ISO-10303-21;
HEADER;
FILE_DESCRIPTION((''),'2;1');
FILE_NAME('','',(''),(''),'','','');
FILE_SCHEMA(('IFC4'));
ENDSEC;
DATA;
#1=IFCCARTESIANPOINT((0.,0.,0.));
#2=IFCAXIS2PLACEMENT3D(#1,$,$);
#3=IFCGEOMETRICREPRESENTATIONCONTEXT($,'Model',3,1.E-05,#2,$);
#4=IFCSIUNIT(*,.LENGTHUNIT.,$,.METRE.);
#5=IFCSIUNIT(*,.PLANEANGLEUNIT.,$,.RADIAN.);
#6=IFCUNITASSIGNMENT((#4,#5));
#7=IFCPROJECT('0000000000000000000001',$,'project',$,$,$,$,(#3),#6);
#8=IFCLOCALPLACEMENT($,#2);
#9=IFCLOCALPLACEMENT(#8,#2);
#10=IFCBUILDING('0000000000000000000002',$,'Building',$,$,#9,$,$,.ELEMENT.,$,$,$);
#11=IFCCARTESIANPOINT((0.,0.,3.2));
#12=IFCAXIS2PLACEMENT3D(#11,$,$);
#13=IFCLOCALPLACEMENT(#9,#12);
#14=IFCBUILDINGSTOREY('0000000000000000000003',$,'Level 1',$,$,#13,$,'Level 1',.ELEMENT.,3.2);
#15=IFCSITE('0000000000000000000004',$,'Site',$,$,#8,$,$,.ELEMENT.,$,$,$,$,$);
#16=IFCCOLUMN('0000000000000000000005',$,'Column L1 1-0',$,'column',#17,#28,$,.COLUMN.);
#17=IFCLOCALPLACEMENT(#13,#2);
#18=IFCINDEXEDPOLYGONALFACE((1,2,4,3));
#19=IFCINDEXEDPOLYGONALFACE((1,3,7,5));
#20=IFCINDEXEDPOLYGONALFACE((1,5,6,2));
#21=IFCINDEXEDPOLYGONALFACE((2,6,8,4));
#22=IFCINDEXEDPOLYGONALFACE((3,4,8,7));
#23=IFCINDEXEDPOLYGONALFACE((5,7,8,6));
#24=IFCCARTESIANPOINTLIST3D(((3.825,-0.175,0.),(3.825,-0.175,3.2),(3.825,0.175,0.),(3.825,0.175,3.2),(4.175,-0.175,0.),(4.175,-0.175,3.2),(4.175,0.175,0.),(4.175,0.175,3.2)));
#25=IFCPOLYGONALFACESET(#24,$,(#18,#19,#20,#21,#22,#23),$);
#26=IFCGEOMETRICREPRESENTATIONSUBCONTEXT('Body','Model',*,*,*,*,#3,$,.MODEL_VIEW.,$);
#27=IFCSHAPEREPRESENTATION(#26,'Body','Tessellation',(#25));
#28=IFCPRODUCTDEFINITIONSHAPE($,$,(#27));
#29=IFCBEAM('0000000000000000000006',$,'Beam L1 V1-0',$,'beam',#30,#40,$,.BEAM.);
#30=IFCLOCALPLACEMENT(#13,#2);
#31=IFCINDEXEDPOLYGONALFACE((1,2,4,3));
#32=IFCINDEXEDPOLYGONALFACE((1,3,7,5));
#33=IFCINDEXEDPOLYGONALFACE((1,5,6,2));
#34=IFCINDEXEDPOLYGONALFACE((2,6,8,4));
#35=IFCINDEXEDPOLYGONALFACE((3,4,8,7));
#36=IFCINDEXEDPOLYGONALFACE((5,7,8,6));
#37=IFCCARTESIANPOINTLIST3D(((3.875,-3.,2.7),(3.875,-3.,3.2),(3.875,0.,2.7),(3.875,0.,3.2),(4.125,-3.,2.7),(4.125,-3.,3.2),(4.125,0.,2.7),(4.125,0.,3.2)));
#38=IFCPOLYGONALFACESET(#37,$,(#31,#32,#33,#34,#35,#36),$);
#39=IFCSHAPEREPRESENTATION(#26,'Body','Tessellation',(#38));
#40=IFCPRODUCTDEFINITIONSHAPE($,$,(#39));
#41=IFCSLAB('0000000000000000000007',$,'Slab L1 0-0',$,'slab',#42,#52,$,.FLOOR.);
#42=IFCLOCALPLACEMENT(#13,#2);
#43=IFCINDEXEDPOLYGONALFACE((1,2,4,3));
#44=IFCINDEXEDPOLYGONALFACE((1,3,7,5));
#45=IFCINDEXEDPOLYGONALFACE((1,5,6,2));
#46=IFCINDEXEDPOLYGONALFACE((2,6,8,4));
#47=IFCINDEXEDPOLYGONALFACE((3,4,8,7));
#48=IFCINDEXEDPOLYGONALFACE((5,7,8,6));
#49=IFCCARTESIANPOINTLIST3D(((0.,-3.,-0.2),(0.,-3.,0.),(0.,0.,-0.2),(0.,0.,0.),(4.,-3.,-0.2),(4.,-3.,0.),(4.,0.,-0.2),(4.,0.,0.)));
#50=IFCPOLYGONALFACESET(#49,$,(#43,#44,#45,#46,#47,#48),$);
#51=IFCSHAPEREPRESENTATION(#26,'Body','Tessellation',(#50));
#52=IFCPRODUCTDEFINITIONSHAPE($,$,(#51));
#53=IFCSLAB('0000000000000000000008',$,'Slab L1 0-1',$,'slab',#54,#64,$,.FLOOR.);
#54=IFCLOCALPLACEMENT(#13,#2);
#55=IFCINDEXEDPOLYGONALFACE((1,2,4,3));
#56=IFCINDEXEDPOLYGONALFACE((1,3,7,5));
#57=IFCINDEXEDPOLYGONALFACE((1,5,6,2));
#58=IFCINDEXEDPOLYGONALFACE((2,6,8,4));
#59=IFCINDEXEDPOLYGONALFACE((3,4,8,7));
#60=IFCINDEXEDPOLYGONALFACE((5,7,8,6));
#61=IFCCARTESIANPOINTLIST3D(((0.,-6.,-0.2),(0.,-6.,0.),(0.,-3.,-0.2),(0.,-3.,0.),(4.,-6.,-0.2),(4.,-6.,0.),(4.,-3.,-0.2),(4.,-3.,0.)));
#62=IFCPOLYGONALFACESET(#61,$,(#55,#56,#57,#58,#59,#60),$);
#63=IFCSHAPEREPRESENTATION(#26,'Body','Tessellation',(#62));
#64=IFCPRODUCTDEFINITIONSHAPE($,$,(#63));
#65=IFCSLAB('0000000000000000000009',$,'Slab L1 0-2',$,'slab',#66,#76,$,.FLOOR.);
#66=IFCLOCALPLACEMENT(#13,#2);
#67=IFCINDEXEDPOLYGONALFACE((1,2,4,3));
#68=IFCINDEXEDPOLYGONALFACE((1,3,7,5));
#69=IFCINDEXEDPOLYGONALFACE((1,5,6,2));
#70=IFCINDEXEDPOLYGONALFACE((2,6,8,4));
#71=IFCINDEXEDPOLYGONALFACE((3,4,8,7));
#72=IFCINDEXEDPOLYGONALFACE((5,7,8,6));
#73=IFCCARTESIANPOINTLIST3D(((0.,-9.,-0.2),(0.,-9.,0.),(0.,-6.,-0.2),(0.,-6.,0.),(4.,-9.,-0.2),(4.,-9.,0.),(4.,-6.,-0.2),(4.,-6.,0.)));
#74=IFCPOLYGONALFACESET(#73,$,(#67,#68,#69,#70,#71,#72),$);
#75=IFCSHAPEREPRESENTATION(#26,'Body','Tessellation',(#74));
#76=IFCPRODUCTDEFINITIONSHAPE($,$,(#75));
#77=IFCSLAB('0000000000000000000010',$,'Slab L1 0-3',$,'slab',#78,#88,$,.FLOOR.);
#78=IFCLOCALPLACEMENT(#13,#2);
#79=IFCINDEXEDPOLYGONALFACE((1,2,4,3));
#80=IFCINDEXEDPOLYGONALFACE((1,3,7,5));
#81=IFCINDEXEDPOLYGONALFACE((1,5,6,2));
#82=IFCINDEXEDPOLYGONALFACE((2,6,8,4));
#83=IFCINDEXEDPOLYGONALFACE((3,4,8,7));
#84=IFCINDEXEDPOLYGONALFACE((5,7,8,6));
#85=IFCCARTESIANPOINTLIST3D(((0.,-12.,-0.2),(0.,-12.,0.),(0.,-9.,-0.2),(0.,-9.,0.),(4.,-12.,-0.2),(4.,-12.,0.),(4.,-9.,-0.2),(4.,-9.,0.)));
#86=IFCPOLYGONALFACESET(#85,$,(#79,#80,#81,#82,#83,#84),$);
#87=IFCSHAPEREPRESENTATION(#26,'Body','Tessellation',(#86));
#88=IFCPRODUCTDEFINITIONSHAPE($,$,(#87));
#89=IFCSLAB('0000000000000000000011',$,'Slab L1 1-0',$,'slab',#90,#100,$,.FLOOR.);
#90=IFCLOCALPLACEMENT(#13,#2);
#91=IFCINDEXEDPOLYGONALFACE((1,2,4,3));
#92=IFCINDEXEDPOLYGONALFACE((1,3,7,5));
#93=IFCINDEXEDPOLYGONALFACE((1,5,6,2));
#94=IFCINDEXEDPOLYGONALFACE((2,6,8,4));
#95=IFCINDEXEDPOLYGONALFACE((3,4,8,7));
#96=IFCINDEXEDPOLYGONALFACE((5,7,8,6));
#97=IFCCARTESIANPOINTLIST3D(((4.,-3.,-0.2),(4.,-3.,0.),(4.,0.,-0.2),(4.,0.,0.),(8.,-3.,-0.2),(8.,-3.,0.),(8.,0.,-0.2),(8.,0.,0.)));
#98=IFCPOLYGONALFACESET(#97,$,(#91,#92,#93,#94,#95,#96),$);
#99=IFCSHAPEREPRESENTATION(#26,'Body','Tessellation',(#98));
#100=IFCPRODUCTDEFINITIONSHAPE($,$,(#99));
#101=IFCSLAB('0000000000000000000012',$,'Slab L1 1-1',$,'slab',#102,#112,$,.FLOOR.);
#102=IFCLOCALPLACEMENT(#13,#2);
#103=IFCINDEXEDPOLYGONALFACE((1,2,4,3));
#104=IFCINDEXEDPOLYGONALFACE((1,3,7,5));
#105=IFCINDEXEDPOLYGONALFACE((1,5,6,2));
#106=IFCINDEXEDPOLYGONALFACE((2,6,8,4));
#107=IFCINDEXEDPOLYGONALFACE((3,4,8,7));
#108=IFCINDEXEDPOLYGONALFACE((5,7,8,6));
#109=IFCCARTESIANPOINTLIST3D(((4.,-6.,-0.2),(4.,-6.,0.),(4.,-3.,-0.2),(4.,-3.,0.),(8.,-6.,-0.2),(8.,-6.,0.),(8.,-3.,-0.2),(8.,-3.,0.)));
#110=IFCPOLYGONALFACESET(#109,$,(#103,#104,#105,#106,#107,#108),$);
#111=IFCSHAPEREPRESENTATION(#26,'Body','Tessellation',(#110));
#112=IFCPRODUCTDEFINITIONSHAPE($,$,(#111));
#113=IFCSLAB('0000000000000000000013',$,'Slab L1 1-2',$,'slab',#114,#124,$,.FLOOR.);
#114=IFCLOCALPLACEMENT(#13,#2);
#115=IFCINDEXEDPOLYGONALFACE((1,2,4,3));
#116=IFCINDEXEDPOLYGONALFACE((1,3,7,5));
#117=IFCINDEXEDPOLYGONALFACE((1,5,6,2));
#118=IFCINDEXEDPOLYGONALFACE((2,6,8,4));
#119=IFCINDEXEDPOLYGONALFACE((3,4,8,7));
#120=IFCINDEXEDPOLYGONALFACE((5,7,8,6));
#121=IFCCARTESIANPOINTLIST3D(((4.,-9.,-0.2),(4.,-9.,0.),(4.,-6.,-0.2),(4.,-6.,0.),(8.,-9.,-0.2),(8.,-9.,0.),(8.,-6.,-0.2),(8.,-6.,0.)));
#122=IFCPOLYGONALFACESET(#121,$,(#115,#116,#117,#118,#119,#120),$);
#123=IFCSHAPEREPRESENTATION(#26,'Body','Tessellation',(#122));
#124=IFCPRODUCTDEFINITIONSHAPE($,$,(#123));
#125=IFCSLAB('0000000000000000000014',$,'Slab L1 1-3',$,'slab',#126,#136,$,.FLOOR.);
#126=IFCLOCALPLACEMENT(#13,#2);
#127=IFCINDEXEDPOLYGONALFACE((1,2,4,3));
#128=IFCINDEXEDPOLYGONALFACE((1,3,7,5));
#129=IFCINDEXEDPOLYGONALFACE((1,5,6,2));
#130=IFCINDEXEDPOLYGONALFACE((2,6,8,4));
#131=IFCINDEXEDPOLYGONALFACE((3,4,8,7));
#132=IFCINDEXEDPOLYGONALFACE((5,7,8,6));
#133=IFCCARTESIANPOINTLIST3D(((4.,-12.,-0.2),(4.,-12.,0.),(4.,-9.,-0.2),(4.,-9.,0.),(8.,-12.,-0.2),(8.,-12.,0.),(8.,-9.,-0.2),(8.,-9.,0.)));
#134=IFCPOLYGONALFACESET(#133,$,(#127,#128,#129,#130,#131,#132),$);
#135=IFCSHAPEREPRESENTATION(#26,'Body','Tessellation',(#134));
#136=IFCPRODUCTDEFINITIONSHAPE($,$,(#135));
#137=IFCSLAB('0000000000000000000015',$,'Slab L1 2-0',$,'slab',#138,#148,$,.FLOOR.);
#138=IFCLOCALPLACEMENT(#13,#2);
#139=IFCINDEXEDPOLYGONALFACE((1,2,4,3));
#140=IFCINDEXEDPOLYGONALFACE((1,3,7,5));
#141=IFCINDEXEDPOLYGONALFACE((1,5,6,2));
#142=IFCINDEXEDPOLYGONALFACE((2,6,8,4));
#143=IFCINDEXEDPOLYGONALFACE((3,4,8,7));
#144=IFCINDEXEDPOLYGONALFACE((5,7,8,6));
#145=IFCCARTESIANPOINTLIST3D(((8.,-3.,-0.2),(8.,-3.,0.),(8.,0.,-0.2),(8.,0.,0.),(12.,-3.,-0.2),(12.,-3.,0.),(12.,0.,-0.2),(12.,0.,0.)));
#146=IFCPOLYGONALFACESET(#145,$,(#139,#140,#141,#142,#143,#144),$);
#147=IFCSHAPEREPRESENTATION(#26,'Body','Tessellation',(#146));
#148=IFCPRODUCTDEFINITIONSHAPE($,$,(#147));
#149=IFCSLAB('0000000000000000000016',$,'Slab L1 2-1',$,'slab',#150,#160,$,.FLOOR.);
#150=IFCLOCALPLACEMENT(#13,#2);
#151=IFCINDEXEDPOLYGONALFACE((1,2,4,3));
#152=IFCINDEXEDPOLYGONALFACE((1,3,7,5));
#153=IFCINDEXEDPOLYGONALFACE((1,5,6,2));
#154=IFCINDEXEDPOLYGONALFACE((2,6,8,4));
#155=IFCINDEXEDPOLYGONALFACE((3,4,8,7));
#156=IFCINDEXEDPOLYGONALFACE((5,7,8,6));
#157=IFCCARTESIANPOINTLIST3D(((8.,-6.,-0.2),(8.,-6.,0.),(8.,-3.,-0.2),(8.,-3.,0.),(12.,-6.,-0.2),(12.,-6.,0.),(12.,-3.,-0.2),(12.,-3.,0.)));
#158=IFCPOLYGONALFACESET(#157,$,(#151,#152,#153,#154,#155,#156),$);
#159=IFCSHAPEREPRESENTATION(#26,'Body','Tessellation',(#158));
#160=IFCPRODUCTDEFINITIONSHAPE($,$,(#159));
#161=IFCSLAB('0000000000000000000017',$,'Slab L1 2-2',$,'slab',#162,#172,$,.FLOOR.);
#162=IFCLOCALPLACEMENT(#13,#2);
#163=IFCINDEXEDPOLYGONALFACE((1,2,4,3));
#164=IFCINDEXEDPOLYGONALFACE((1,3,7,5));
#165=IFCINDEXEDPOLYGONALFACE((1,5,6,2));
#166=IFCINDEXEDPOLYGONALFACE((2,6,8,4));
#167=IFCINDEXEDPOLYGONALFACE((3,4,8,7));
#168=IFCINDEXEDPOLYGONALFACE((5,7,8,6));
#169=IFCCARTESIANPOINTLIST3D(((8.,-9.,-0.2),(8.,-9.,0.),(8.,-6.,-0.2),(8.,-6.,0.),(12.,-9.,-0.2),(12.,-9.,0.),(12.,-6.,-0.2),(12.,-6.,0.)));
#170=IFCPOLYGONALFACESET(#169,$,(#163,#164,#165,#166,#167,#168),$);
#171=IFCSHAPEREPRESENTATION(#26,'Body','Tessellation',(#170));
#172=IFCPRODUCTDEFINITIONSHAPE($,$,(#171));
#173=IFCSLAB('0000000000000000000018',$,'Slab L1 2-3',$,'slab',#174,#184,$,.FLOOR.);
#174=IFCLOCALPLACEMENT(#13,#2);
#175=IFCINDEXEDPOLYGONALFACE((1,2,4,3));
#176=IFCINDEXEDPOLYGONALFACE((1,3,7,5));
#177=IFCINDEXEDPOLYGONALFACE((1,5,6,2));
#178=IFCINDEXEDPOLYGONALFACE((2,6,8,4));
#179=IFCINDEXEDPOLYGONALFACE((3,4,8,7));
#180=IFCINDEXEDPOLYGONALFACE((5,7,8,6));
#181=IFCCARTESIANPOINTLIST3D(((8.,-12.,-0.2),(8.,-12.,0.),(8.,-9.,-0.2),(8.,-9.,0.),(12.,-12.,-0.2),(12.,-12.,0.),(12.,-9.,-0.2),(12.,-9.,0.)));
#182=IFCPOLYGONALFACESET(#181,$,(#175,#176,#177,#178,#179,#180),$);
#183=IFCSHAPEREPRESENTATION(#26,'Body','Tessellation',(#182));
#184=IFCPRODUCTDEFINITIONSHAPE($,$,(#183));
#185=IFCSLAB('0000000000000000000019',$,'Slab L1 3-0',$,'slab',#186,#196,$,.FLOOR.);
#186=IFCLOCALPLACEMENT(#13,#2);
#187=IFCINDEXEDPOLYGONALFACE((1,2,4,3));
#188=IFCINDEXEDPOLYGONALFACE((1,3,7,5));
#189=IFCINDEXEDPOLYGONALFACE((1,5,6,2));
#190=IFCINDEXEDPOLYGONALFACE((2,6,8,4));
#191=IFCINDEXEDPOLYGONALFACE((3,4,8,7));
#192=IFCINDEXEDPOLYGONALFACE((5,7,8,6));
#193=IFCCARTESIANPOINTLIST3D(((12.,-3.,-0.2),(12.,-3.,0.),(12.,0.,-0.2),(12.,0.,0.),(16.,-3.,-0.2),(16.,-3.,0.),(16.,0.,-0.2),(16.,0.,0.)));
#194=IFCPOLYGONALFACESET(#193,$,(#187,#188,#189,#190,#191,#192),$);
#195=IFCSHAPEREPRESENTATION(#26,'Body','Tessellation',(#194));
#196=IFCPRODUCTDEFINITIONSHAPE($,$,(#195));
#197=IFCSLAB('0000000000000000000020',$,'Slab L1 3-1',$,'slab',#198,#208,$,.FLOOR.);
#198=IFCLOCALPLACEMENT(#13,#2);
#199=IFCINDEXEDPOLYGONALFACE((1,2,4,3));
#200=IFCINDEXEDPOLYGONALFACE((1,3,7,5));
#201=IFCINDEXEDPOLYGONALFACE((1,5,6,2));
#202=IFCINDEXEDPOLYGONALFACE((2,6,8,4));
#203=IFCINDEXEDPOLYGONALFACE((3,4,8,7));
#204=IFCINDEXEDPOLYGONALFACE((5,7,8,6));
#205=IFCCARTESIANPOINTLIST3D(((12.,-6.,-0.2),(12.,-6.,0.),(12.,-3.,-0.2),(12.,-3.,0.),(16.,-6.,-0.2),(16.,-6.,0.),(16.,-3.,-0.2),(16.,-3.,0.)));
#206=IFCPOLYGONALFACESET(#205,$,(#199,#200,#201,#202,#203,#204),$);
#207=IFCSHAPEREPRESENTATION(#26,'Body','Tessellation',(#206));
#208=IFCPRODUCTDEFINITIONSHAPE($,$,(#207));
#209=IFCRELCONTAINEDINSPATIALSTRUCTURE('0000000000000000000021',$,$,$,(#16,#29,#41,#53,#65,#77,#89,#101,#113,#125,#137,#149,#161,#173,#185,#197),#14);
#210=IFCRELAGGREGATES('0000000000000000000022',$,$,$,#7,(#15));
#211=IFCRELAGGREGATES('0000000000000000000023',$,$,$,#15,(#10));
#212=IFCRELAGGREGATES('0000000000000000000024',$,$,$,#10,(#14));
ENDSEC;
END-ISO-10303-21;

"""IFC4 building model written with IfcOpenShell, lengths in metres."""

from ifc_helpers import new_model, si_unit, frame, origin, origin_2d, place, context, subcontext, project, spatial, polyline, rectangle, outline, extrude, element, save


model = new_model("IFC4")

# Units and contexts
model_context = context("Model", 3, precision=1e-05, world=origin())
body_context = subcontext(model_context, "Body", "Model", "MODEL_VIEW")
ifc_project = project(units=[si_unit("LENGTHUNIT", "METRE"), si_unit("PLANEANGLEUNIT", "RADIAN")], contexts=[model_context])

# Site, building, storey
site_placement = place(None, origin())
site = spatial("IfcSite", under=ifc_project, at=site_placement, Name="Site", CompositionType="ELEMENT")
building_placement = place(site_placement, origin())
building = spatial("IfcBuilding", under=site, at=building_placement, Name="Building", CompositionType="ELEMENT")
storey_placement = place(building_placement, frame((0.0, 0.0, 3.2)))
storey = spatial("IfcBuildingStorey", under=building, at=storey_placement, Name="Level 1", LongName="Level 1", CompositionType="ELEMENT", Elevation=3.2)

# Column
column_placement = place(storey_placement, frame((4.0, 0.0, 0.0)))
element("IfcColumn", 1, at=column_placement, inside=storey, Name="Column L1 1-0", ObjectType="column", PredefinedType="COLUMN", context=body_context, shape_type="SweptSolid", body=[
    extrude(rectangle(XDim=0.35, YDim=0.35, at=origin_2d()), origin(), (0.0, 0.0, 1.0), 3.2),
])

# Beam
beam_placement = place(storey_placement, frame((4.0, 0.0, 2.95), z_axis=(0.0, -1.0, 0.0), x_axis=(0.0, 0.0, 1.0)))
element("IfcBeam", 2, at=beam_placement, inside=storey, Name="Beam L1 V1-0", ObjectType="beam", PredefinedType="BEAM", context=body_context, shape_type="SweptSolid", body=[
    extrude(rectangle(XDim=0.5, YDim=0.25, at=origin_2d()), origin(), (0.0, 0.0, 1.0), 3.0),
])

# Slabs
slab_1_placement = place(storey_placement, frame((0.0, 0.0, -0.2)))
element("IfcSlab", 3, at=slab_1_placement, inside=storey, Name="Slab L1 0-0", ObjectType="slab", PredefinedType="FLOOR", context=body_context, shape_type="SweptSolid", body=[
    extrude(outline(polyline([(0.0, -3.0), (4.0, -3.0), (4.0, 0.0), (0.0, 0.0), (0.0, -3.0)])), origin(), (0.0, 0.0, 1.0), 0.2),
])
slab_2_placement = place(storey_placement, frame((0.0, 0.0, -0.2)))
element("IfcSlab", 4, at=slab_2_placement, inside=storey, Name="Slab L1 0-1", ObjectType="slab", PredefinedType="FLOOR", context=body_context, shape_type="SweptSolid", body=[
    extrude(outline(polyline([(0.0, -6.0), (4.0, -6.0), (4.0, -3.0), (0.0, -3.0), (0.0, -6.0)])), origin(), (0.0, 0.0, 1.0), 0.2),
])
slab_3_placement = place(storey_placement, frame((0.0, 0.0, -0.2)))
element("IfcSlab", 5, at=slab_3_placement, inside=storey, Name="Slab L1 0-2", ObjectType="slab", PredefinedType="FLOOR", context=body_context, shape_type="SweptSolid", body=[
    extrude(outline(polyline([(0.0, -9.0), (4.0, -9.0), (4.0, -6.0), (0.0, -6.0), (0.0, -9.0)])), origin(), (0.0, 0.0, 1.0), 0.2),
])
slab_4_placement = place(storey_placement, frame((0.0, 0.0, -0.2)))
element("IfcSlab", 6, at=slab_4_placement, inside=storey, Name="Slab L1 0-3", ObjectType="slab", PredefinedType="FLOOR", context=body_context, shape_type="SweptSolid", body=[
    extrude(outline(polyline([(0.0, -12.0), (4.0, -12.0), (4.0, -9.0), (0.0, -9.0), (0.0, -12.0)])), origin(), (0.0, 0.0, 1.0), 0.2),
])
slab_5_placement = place(storey_placement, frame((0.0, 0.0, -0.2)))
element("IfcSlab", 7, at=slab_5_placement, inside=storey, Name="Slab L1 1-0", ObjectType="slab", PredefinedType="FLOOR", context=body_context, shape_type="SweptSolid", body=[
    extrude(outline(polyline([(4.0, -3.0), (8.0, -3.0), (8.0, 0.0), (4.0, 0.0), (4.0, -3.0)])), origin(), (0.0, 0.0, 1.0), 0.2),
])
slab_6_placement = place(storey_placement, frame((0.0, 0.0, -0.2)))
element("IfcSlab", 8, at=slab_6_placement, inside=storey, Name="Slab L1 1-1", ObjectType="slab", PredefinedType="FLOOR", context=body_context, shape_type="SweptSolid", body=[
    extrude(outline(polyline([(4.0, -6.0), (8.0, -6.0), (8.0, -3.0), (4.0, -3.0), (4.0, -6.0)])), origin(), (0.0, 0.0, 1.0), 0.2),
])
slab_7_placement = place(storey_placement, frame((0.0, 0.0, -0.2)))
element("IfcSlab", 9, at=slab_7_placement, inside=storey, Name="Slab L1 1-2", ObjectType="slab", PredefinedType="FLOOR", context=body_context, shape_type="SweptSolid", body=[
    extrude(outline(polyline([(4.0, -9.0), (8.0, -9.0), (8.0, -6.0), (4.0, -6.0), (4.0, -9.0)])), origin(), (0.0, 0.0, 1.0), 0.2),
])
slab_8_placement = place(storey_placement, frame((0.0, 0.0, -0.2)))
element("IfcSlab", 10, at=slab_8_placement, inside=storey, Name="Slab L1 1-3", ObjectType="slab", PredefinedType="FLOOR", context=body_context, shape_type="SweptSolid", body=[
    extrude(outline(polyline([(4.0, -12.0), (8.0, -12.0), (8.0, -9.0), (4.0, -9.0), (4.0, -12.0)])), origin(), (0.0, 0.0, 1.0), 0.2),
])
slab_9_placement = place(storey_placement, frame((0.0, 0.0, -0.2)))
element("IfcSlab", 11, at=slab_9_placement, inside=storey, Name="Slab L1 2-0", ObjectType="slab", PredefinedType="FLOOR", context=body_context, shape_type="SweptSolid", body=[
    extrude(outline(polyline([(8.0, -3.0), (12.0, -3.0), (12.0, 0.0), (8.0, 0.0), (8.0, -3.0)])), origin(), (0.0, 0.0, 1.0), 0.2),
])
slab_10_placement = place(storey_placement, frame((0.0, 0.0, -0.2)))
element("IfcSlab", 12, at=slab_10_placement, inside=storey, Name="Slab L1 2-1", ObjectType="slab", PredefinedType="FLOOR", context=body_context, shape_type="SweptSolid", body=[
    extrude(outline(polyline([(8.0, -6.0), (12.0, -6.0), (12.0, -3.0), (8.0, -3.0), (8.0, -6.0)])), origin(), (0.0, 0.0, 1.0), 0.2),
])
slab_11_placement = place(storey_placement, frame((0.0, 0.0, -0.2)))
element("IfcSlab", 13, at=slab_11_placement, inside=storey, Name="Slab L1 2-2", ObjectType="slab", PredefinedType="FLOOR", context=body_context, shape_type="SweptSolid", body=[
    extrude(outline(polyline([(8.0, -9.0), (12.0, -9.0), (12.0, -6.0), (8.0, -6.0), (8.0, -9.0)])), origin(), (0.0, 0.0, 1.0), 0.2),
])
slab_12_placement = place(storey_placement, frame((0.0, 0.0, -0.2)))
element("IfcSlab", 14, at=slab_12_placement, inside=storey, Name="Slab L1 2-3", ObjectType="slab", PredefinedType="FLOOR", context=body_context, shape_type="SweptSolid", body=[
    extrude(outline(polyline([(8.0, -12.0), (12.0, -12.0), (12.0, -9.0), (8.0, -9.0), (8.0, -12.0)])), origin(), (0.0, 0.0, 1.0), 0.2),
])
slab_13_placement = place(storey_placement, frame((0.0, 0.0, -0.2)))
element("IfcSlab", 15, at=slab_13_placement, inside=storey, Name="Slab L1 3-0", ObjectType="slab", PredefinedType="FLOOR", context=body_context, shape_type="SweptSolid", body=[
    extrude(outline(polyline([(12.0, -3.0), (16.0, -3.0), (16.0, 0.0), (12.0, 0.0), (12.0, -3.0)])), origin(), (0.0, 0.0, 1.0), 0.2),
])
slab_14_placement = place(storey_placement, frame((0.0, 0.0, -0.2)))
element("IfcSlab", 16, at=slab_14_placement, inside=storey, Name="Slab L1 3-1", ObjectType="slab", PredefinedType="FLOOR", context=body_context, shape_type="SweptSolid", body=[
    extrude(outline(polyline([(12.0, -6.0), (16.0, -6.0), (16.0, -3.0), (12.0, -3.0), (12.0, -6.0)])), origin(), (0.0, 0.0, 1.0), 0.2),
])

save(model, "model.ifc")
